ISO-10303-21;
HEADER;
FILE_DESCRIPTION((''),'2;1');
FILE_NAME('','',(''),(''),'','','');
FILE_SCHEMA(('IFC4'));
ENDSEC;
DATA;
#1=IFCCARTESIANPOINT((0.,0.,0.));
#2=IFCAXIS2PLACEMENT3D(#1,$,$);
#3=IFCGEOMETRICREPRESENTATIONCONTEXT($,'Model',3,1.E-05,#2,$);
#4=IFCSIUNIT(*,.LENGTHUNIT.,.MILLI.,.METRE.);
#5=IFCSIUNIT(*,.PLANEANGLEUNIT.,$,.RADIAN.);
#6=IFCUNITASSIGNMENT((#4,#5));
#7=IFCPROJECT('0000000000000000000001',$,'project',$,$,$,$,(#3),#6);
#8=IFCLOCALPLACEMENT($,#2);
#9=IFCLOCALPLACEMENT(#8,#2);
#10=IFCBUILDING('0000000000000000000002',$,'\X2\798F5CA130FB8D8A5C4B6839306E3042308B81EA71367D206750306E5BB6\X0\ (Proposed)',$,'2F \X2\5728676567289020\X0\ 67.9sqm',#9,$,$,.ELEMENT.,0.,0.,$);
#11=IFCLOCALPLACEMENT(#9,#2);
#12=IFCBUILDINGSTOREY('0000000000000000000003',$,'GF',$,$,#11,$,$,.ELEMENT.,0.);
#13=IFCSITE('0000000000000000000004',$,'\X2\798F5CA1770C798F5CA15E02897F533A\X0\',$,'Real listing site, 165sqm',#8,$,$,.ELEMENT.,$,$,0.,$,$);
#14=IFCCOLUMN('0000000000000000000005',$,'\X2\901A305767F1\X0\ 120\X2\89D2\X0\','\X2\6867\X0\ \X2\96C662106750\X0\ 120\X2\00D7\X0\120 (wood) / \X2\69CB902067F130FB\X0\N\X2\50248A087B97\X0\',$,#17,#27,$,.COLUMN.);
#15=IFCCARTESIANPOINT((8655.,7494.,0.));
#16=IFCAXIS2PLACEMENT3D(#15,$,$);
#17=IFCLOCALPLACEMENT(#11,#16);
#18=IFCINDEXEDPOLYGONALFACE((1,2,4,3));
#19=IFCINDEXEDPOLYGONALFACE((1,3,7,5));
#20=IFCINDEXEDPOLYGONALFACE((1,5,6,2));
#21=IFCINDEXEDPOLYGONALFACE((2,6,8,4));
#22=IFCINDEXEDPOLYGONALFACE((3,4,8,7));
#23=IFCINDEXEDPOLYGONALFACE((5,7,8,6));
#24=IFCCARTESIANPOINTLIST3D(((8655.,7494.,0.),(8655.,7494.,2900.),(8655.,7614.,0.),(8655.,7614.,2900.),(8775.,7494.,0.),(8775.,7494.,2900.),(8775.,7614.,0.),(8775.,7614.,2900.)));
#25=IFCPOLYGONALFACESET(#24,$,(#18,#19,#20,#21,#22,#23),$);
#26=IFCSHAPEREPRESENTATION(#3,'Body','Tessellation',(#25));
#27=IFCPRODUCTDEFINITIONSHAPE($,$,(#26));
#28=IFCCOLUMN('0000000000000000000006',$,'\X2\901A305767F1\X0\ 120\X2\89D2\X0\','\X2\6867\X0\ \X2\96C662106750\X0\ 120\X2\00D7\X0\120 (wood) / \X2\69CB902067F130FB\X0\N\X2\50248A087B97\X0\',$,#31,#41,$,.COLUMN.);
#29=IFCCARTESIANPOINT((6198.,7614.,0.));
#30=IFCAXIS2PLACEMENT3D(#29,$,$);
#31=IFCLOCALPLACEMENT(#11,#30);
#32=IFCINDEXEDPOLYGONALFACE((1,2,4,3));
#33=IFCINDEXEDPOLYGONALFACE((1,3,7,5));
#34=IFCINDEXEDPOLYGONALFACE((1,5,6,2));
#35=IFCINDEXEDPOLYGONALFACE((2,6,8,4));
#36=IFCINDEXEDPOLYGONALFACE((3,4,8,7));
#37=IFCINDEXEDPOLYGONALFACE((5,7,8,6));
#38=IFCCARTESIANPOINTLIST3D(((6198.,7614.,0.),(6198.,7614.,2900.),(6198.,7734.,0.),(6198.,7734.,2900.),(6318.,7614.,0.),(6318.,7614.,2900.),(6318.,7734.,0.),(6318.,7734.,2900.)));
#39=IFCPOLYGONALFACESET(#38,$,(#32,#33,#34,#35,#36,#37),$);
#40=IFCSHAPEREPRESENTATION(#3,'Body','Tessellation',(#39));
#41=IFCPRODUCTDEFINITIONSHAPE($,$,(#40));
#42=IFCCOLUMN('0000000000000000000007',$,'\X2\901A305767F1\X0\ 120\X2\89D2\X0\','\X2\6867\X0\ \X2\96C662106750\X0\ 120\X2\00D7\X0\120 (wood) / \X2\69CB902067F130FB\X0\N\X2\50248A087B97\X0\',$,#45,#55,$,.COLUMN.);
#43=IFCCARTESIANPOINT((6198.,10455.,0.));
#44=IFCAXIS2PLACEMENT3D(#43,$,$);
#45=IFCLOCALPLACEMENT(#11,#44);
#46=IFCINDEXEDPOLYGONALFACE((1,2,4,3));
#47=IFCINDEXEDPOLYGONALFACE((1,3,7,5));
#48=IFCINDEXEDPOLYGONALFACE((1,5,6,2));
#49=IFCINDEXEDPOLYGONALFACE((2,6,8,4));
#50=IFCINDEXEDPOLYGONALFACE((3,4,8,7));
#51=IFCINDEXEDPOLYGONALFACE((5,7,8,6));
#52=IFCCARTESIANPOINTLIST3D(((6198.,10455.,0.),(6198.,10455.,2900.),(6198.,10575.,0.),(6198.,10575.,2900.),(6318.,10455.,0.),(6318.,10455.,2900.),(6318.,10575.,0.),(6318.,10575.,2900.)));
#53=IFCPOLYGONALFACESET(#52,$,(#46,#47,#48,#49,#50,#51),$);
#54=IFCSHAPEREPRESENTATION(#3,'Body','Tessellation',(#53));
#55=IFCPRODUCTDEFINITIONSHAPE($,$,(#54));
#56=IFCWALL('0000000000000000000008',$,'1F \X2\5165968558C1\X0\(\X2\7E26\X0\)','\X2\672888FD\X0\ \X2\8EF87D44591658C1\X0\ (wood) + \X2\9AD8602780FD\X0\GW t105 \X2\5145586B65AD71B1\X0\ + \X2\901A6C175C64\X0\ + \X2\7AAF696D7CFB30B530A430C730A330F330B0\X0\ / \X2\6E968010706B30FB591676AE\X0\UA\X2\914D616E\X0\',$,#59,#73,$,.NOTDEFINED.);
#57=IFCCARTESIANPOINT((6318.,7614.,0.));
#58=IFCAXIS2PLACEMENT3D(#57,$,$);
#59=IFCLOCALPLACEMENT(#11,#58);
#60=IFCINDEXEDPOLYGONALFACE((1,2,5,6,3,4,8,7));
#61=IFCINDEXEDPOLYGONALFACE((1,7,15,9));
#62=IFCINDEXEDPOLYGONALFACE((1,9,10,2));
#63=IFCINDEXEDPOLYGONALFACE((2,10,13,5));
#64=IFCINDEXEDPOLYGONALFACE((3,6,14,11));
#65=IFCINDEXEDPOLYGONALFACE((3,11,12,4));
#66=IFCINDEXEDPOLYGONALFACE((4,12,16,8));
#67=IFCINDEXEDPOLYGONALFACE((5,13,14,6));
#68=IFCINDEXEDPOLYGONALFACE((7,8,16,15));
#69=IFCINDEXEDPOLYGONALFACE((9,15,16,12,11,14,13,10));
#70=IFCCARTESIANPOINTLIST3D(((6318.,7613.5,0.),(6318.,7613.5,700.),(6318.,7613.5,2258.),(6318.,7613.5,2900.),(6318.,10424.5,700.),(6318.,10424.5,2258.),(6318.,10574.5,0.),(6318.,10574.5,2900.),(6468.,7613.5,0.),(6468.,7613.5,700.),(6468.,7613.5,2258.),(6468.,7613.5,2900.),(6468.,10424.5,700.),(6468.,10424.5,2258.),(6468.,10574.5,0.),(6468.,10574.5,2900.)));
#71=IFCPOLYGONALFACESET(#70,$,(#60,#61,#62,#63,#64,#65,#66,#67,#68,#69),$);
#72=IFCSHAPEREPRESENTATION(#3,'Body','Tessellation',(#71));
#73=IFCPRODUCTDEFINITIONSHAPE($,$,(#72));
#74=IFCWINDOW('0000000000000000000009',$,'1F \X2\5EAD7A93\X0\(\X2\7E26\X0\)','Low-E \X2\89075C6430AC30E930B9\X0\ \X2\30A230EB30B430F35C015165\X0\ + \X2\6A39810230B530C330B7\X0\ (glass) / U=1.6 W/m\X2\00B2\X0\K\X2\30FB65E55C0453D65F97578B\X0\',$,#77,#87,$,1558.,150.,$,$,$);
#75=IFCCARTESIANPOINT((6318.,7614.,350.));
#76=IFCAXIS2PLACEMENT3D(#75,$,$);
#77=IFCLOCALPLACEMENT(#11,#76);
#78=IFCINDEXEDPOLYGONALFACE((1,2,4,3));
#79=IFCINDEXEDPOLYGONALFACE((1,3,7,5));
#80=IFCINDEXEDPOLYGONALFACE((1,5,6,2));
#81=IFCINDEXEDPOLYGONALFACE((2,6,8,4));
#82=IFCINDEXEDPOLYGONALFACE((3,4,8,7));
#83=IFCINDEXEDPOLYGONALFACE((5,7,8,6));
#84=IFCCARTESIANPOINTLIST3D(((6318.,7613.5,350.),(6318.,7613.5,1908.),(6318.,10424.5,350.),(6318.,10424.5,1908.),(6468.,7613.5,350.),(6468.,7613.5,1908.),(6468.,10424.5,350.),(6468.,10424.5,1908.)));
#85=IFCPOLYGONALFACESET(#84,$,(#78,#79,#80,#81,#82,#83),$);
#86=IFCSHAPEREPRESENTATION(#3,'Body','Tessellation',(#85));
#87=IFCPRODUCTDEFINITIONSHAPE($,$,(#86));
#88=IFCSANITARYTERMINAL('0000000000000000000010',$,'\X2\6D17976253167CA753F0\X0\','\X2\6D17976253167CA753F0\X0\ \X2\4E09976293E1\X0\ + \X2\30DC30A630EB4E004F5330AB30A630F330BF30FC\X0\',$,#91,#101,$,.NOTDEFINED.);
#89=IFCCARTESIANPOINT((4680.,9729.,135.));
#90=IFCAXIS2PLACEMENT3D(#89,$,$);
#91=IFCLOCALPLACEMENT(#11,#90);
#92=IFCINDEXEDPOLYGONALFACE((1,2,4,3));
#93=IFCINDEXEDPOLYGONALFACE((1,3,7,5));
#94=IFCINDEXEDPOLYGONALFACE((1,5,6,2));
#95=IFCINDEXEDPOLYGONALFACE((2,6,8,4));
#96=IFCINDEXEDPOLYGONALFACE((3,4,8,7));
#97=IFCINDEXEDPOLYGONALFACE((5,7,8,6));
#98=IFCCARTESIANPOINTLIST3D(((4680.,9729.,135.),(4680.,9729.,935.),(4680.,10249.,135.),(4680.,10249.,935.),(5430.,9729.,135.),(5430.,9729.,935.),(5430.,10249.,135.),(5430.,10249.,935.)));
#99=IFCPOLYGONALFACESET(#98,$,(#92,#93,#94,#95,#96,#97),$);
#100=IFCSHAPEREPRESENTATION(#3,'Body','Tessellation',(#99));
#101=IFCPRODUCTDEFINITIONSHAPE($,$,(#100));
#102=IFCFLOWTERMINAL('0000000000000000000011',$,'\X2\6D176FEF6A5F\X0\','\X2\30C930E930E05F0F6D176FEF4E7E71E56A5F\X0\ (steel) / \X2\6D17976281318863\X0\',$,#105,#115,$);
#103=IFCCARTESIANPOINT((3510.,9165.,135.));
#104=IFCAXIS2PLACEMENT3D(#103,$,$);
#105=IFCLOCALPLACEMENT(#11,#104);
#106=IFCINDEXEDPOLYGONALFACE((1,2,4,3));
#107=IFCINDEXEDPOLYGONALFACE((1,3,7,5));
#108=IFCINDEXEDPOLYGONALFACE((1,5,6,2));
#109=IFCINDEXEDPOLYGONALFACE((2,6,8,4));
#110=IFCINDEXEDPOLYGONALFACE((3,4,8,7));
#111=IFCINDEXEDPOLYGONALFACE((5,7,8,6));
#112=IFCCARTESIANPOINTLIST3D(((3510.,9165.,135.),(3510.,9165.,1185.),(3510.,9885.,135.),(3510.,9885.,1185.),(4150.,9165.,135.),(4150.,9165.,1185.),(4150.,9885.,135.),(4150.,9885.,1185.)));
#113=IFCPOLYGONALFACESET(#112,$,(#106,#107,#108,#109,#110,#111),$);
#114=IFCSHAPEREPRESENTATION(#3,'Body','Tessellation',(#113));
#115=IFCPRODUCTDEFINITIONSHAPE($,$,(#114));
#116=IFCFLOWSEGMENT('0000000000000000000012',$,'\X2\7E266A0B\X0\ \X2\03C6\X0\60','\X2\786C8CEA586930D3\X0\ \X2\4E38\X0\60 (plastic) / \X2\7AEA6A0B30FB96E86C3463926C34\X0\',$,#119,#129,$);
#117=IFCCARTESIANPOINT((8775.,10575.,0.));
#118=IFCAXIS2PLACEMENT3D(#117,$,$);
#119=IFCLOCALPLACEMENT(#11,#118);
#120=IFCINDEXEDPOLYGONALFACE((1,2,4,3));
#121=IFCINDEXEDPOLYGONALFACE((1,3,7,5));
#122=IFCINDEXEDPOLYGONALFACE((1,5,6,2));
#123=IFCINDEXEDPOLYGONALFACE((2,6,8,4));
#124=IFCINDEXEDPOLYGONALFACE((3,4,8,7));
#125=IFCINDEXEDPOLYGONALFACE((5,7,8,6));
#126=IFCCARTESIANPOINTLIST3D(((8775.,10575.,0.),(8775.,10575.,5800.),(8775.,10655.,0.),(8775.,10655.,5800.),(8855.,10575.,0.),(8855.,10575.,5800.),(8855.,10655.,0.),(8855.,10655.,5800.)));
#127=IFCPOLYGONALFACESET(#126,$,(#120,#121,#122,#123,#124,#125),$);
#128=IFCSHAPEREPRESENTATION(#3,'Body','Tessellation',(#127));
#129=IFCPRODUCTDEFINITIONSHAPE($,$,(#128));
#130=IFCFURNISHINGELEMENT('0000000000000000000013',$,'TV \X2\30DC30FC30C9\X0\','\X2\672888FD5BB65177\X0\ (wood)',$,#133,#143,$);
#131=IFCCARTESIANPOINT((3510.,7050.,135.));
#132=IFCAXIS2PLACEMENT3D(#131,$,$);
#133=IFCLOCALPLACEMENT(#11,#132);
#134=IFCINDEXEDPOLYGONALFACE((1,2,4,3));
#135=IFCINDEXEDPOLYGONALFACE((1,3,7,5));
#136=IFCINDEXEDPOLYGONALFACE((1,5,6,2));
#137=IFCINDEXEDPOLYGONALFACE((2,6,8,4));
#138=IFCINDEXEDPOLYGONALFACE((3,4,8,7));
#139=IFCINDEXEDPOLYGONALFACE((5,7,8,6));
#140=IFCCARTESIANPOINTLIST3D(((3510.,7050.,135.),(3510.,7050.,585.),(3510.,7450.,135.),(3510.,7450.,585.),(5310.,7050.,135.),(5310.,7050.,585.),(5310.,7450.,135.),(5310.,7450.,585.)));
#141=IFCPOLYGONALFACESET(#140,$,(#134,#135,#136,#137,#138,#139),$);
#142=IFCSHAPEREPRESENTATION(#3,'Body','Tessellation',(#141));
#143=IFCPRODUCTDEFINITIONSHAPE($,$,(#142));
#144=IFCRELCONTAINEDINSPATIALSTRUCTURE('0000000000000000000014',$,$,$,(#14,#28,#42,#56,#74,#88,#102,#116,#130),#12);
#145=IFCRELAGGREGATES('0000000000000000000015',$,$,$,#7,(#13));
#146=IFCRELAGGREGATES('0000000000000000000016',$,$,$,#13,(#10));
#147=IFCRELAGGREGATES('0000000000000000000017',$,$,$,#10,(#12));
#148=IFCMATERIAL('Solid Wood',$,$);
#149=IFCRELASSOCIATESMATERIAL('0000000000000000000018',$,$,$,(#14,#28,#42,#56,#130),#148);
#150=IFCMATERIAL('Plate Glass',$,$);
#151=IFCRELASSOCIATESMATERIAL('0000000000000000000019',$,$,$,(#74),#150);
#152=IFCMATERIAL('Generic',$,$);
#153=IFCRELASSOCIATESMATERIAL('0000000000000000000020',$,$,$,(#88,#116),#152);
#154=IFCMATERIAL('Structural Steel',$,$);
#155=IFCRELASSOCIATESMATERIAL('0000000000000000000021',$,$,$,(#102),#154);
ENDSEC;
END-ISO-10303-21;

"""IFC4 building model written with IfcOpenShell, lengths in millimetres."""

from ifc_helpers import new_model, si_unit, frame, frame_2d, origin, place, context, project, spatial, rectangle, extrude, material, element, fill, save


model = new_model("IFC4")

# Units and contexts
model_context = context("Model", 3, precision=1e-05, world=origin())
ifc_project = project(units=[si_unit("LENGTHUNIT", "METRE", prefix="MILLI"), si_unit("PLANEANGLEUNIT", "RADIAN")], contexts=[model_context])

# Site, building, storey
site_placement = place(None, origin())
site = spatial("IfcSite", under=ifc_project, at=site_placement, Name="福岡県福岡市西区", ObjectType="Real listing site, 165sqm", CompositionType="ELEMENT", RefElevation=0.0)
building_placement = place(site_placement, origin())
building = spatial("IfcBuilding", under=site, at=building_placement, Name="福岡・越屋根のある自然素材の家 (Proposed)", ObjectType="2F 在来木造 67.9sqm", CompositionType="ELEMENT", ElevationOfRefHeight=0.0, ElevationOfTerrain=0.0)
storey_placement = place(building_placement, origin())
storey = spatial("IfcBuildingStorey", under=building, at=storey_placement, Name="GF", CompositionType="ELEMENT", Elevation=0.0)

# Columns
ifc_material_1 = material(Name="Solid Wood")
column_1_placement = place(storey_placement, frame((8655.0, 7494.0, 0.0)))
element("IfcColumn", 1, at=column_1_placement, inside=storey, material=ifc_material_1, Name="通し柱 120角", Description="桧 集成材 120×120 (wood) / 構造柱・N値計算", PredefinedType="COLUMN", context=model_context, shape_type="SweptSolid", body=[
    extrude(rectangle(XDim=120.0, YDim=120.0, at=frame_2d((60.0, 60.0))), frame((8655.0, 7494.0, 0.0)), (0.0, 0.0, 1.0), 2900.0),
])
column_2_placement = place(storey_placement, frame((6198.0, 7614.0, 0.0)))
element("IfcColumn", 2, at=column_2_placement, inside=storey, material=ifc_material_1, Name="通し柱 120角", Description="桧 集成材 120×120 (wood) / 構造柱・N値計算", PredefinedType="COLUMN", context=model_context, shape_type="SweptSolid", body=[
    extrude(rectangle(XDim=120.0, YDim=120.0, at=frame_2d((60.0, 60.0))), frame((6198.0, 7614.0, 0.0)), (0.0, 0.0, 1.0), 2900.0),
])
column_3_placement = place(storey_placement, frame((6198.0, 10455.0, 0.0)))
element("IfcColumn", 3, at=column_3_placement, inside=storey, material=ifc_material_1, Name="通し柱 120角", Description="桧 集成材 120×120 (wood) / 構造柱・N値計算", PredefinedType="COLUMN", context=model_context, shape_type="SweptSolid", body=[
    extrude(rectangle(XDim=120.0, YDim=120.0, at=frame_2d((60.0, 60.0))), frame((6198.0, 10455.0, 0.0)), (0.0, 0.0, 1.0), 2900.0),
])

# Wall, opening, window
wall_1_placement = place(storey_placement, frame((6318.0, 7614.0, 0.0)))
wall_1 = element("IfcWall", 4, at=wall_1_placement, inside=storey, material=ifc_material_1, Name="1F 入隅壁(縦)", Description="木製 軸組外壁 (wood) + 高性能GW t105 充填断熱 + 通気層 + 窯業系サイディング / 準耐火・外皮UA配慮", PredefinedType="NOTDEFINED", context=model_context, shape_type="SweptSolid", body=[
    extrude(rectangle(XDim=150.0, YDim=2961.0, at=frame_2d((75.0, 1480.0))), frame((6318.0, 7614.0, 0.0)), (0.0, 0.0, 1.0), 2900.0),
])
opening_placement = place(storey_placement, frame((6318.0, 7614.0, 350.0)))
opening = element("IfcOpeningElement", 5, at=opening_placement, cuts=wall_1, PredefinedType="NOTDEFINED", context=model_context, shape_type="SweptSolid", body=[
    extrude(rectangle(XDim=150.0, YDim=2811.0, at=frame_2d((75.0, 1405.0))), frame((6318.0, 7614.0, 350.0)), (0.0, 0.0, 1.0), 1558.0),
])
ifc_material_2 = material(Name="Plate Glass")
window_placement = place(storey_placement, frame((6318.0, 7614.0, 350.0)))
window = element("IfcWindow", 6, at=window_placement, inside=storey, material=ifc_material_2, Name="1F 庭窓(縦)", Description="Low-E 複層ガラス アルゴン封入 + 樹脂サッシ (glass) / U=1.6 W/m²K・日射取得型", OverallHeight=1558.0, OverallWidth=150.0, context=model_context, shape_type="SweptSolid", body=[
    extrude(rectangle(XDim=150.0, YDim=2811.0, at=frame_2d((75.0, 1405.0))), frame((6318.0, 7614.0, 350.0)), (0.0, 0.0, 1.0), 1558.0),
])
fill(opening, window)

# Sanitary terminal
ifc_material_3 = material(Name="Generic")
sanitary_terminal_placement = place(storey_placement, frame((4680.0, 9729.0, 135.0)))
element("IfcSanitaryTerminal", 7, at=sanitary_terminal_placement, inside=storey, material=ifc_material_3, Name="洗面化粧台", Description="洗面化粧台 三面鏡 + ボウル一体カウンター", PredefinedType="NOTDEFINED", context=model_context, shape_type="SweptSolid", body=[
    extrude(rectangle(XDim=750.0, YDim=520.0, at=frame_2d((375.0, 260.0))), frame((4680.0, 9729.0, 135.0)), (0.0, 0.0, 1.0), 800.0),
])

# Flow terminal
ifc_material_4 = material(Name="Structural Steel")
flow_terminal_placement = place(storey_placement, frame((3510.0, 9165.0, 135.0)))
element("IfcFlowTerminal", 8, at=flow_terminal_placement, inside=storey, material=ifc_material_4, Name="洗濯機", Description="ドラム式洗濯乾燥機 (steel) / 洗面脱衣", context=model_context, shape_type="SweptSolid", body=[
    extrude(rectangle(XDim=640.0, YDim=720.0, at=frame_2d((320.0, 360.0))), frame((3510.0, 9165.0, 135.0)), (0.0, 0.0, 1.0), 1050.0),
])

# Flow segment
flow_segment_placement = place(storey_placement, frame((8775.0, 10575.0, 0.0)))
element("IfcFlowSegment", 9, at=flow_segment_placement, inside=storey, material=ifc_material_3, Name="縦樋 φ60", Description="硬質塩ビ 丸60 (plastic) / 竪樋・雨水排水", context=model_context, shape_type="SweptSolid", body=[
    extrude(rectangle(XDim=80.0, YDim=80.0, at=frame_2d((40.0, 40.0))), frame((8775.0, 10575.0, 0.0)), (0.0, 0.0, 1.0), 5800.0),
])

# Furnishing element
furnishing_placement = place(storey_placement, frame((3510.0, 7050.0, 135.0)))
element("IfcFurnishingElement", 10, at=furnishing_placement, inside=storey, material=ifc_material_1, Name="TV ボード", Description="木製家具 (wood)", context=model_context, shape_type="SweptSolid", body=[
    extrude(rectangle(XDim=1800.0, YDim=400.0, at=frame_2d((900.0, 200.0))), frame((3510.0, 7050.0, 135.0)), (0.0, 0.0, 1.0), 450.0),
])

save(model, "model.ifc")
